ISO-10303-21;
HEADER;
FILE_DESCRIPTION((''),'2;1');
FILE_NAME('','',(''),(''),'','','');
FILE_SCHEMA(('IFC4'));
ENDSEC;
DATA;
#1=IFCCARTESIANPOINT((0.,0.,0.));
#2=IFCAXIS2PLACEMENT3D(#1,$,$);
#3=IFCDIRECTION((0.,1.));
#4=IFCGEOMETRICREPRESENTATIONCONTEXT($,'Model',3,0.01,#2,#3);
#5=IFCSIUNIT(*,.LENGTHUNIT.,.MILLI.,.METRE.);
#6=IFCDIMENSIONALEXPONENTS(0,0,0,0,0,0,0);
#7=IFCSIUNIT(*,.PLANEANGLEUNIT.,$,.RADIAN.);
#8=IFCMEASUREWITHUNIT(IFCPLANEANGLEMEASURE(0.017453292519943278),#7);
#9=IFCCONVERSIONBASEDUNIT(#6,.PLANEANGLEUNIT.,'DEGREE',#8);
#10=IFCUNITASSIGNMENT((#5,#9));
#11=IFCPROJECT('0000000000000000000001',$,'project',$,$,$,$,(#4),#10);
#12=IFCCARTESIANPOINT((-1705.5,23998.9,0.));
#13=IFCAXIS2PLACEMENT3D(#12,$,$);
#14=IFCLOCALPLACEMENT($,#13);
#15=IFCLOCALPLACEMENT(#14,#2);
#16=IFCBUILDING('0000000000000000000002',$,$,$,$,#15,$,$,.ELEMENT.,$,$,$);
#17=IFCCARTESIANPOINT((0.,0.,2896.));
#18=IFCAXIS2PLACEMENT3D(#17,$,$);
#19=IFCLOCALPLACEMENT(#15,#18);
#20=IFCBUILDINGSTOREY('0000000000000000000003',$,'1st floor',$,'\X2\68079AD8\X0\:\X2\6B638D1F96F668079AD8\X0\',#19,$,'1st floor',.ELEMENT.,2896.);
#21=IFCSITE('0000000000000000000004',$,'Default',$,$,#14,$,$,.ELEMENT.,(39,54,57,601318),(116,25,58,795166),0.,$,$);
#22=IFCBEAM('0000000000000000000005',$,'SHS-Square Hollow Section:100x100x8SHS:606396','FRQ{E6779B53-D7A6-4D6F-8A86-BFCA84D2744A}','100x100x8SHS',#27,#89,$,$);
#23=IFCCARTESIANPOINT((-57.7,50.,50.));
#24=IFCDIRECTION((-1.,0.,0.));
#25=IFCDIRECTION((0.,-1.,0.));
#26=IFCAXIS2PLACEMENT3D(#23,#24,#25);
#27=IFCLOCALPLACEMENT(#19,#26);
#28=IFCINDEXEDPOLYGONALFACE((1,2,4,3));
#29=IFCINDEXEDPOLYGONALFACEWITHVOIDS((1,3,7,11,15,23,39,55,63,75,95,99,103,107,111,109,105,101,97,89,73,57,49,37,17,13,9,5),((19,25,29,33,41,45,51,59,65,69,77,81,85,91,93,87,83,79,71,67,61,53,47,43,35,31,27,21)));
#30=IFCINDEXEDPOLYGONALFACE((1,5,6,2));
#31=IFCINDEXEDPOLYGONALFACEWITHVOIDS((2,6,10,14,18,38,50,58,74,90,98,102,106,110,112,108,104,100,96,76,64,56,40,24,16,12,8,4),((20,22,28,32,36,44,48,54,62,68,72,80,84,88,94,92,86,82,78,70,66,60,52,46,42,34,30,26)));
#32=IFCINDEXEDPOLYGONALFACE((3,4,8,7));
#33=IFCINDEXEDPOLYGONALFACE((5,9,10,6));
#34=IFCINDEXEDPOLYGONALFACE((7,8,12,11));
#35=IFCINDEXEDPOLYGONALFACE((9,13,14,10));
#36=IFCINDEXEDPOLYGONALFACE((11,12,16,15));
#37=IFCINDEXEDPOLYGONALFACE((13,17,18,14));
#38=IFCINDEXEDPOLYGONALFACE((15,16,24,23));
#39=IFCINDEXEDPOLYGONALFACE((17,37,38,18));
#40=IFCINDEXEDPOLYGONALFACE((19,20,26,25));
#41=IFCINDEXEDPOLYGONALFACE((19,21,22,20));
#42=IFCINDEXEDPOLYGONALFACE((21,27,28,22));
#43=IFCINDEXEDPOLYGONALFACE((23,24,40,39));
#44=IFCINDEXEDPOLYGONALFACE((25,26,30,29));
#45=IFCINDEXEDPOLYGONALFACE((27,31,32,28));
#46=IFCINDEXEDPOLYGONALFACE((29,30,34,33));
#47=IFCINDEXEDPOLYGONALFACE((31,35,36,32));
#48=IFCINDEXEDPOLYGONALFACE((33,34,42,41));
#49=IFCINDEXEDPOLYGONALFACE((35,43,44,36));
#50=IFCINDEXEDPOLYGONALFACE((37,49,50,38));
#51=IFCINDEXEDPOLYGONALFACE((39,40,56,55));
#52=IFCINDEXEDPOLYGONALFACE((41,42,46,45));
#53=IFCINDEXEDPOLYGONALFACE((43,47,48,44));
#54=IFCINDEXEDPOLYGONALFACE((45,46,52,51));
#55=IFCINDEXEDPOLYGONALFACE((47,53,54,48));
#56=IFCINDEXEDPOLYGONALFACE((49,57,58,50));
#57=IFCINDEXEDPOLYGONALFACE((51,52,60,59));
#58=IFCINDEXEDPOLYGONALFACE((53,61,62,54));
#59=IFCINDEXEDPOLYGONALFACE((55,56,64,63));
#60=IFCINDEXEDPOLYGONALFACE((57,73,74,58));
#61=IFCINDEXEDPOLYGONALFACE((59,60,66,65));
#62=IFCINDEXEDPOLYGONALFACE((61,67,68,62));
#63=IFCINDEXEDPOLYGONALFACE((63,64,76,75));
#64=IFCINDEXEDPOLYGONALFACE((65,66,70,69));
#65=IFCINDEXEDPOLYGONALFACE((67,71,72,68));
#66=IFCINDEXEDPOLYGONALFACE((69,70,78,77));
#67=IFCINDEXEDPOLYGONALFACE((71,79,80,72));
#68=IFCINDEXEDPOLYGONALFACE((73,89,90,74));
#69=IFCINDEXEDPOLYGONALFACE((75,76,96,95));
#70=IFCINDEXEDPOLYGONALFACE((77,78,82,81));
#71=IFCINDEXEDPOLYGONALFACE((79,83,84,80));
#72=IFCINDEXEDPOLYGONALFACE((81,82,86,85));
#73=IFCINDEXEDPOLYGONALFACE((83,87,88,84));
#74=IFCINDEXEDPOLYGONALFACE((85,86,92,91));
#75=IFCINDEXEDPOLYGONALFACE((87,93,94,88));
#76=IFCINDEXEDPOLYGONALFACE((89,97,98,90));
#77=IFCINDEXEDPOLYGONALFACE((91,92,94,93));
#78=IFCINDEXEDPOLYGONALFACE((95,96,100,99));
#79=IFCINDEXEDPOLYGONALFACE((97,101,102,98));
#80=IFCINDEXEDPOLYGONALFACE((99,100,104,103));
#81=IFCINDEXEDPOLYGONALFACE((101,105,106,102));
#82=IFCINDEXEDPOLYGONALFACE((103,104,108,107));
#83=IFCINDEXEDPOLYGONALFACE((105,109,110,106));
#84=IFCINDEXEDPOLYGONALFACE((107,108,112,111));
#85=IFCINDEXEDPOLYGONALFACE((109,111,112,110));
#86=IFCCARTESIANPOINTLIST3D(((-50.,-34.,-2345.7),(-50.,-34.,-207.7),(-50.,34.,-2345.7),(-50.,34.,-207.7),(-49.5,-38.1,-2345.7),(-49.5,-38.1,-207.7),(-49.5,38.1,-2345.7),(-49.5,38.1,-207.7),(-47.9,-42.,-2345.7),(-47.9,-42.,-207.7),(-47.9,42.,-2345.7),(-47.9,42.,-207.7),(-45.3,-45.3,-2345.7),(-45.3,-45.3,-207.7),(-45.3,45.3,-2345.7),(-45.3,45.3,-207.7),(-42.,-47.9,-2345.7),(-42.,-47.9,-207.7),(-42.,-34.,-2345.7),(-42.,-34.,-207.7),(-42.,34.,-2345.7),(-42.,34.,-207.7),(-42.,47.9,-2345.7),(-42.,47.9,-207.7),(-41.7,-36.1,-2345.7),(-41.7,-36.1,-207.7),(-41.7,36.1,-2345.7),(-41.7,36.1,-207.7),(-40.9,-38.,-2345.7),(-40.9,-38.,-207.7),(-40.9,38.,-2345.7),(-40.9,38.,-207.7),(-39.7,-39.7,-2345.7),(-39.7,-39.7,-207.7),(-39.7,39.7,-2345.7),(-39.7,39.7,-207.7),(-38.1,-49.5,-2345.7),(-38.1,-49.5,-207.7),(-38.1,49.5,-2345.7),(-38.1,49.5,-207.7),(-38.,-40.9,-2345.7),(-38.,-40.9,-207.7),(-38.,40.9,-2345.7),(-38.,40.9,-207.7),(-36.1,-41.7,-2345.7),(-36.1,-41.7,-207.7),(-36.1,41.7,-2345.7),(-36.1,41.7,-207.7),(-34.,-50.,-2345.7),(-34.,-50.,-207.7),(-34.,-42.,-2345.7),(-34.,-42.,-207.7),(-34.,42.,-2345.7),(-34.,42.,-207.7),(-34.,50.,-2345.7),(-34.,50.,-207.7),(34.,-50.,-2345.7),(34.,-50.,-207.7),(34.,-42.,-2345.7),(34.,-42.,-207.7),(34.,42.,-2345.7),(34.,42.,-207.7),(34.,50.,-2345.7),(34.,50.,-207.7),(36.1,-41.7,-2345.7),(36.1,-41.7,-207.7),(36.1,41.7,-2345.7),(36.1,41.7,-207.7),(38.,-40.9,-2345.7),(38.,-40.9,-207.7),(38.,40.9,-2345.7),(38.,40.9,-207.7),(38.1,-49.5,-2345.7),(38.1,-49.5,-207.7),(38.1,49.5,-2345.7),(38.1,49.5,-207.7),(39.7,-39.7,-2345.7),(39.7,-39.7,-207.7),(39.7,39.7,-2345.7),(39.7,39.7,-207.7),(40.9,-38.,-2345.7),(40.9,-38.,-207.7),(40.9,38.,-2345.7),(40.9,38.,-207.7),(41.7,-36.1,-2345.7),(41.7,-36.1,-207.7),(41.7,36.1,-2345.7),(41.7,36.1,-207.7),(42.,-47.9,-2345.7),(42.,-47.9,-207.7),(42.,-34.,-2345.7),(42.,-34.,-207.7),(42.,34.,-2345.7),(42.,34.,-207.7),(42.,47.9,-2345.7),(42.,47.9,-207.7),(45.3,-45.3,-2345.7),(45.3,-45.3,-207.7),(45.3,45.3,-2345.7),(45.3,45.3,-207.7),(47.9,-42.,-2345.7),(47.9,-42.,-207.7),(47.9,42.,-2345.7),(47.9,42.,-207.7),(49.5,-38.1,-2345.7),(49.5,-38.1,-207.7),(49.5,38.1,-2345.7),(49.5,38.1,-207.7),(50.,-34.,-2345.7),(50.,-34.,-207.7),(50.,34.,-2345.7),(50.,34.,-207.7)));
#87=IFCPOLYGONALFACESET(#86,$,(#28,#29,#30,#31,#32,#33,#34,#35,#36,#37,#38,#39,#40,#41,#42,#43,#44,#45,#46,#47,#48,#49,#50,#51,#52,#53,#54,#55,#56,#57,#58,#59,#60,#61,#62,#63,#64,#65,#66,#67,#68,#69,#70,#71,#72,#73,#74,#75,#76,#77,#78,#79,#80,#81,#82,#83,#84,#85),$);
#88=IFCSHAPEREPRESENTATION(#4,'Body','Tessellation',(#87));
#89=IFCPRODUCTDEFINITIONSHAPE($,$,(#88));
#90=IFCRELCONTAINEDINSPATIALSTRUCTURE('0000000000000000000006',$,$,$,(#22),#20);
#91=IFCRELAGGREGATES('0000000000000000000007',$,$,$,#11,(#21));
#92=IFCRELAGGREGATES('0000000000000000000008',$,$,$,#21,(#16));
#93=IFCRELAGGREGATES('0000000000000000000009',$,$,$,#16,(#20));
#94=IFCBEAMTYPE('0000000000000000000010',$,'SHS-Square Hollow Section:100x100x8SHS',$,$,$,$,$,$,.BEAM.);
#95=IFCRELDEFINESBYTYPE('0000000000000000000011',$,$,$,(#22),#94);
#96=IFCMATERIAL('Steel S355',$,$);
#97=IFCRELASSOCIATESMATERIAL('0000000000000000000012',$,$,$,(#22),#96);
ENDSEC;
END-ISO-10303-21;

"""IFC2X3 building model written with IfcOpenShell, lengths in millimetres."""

from ifc_helpers import new_model, entity, si_unit, converted_unit, direction, frame, origin, origin_2d, place, context, project, spatial, hollow_rectangle, extrude, clip, halfspace, material, type_object, element, save


model = new_model("IFC2X3")

# Units and contexts
model_context = context("Model", 3, precision=0.01, world=origin(), true_north=direction((0.0, 1.0)))
ifc_project = project(units=[si_unit("LENGTHUNIT", "METRE", prefix="MILLI"), converted_unit("PLANEANGLEUNIT", "DEGREE", entity("IfcPlaneAngleMeasure", 0.017453292519943278), si_unit("PLANEANGLEUNIT", "RADIAN"), dimensions=[0, 0, 0, 0, 0, 0, 0])], contexts=[model_context])

# Site, building, storey
site_placement = place(None, frame((-1705.5, 23998.9, 0.0)))
site = spatial("IfcSite", under=ifc_project, at=site_placement, Name="Default", CompositionType="ELEMENT", RefLatitude=(39, 54, 57, 601318), RefLongitude=(116, 25, 58, 795166), RefElevation=0.0)
building_placement = place(site_placement, origin())
building = spatial("IfcBuilding", under=site, at=building_placement, CompositionType="ELEMENT")
storey_placement = place(building_placement, frame((0.0, 0.0, 2896.0)))
storey = spatial("IfcBuildingStorey", under=building, at=storey_placement, Name="1st floor", ObjectType="标高:正负零标高", LongName="1st floor", CompositionType="ELEMENT", Elevation=2896.0)

# Shared definitions
ifc_material_1 = material(Name="Steel S355")

# Beam
beam_type_1 = type_object("IfcBeamType", Name="SHS-Square Hollow Section:100x100x8SHS", PredefinedType="BEAM")
beam_1_placement = place(storey_placement, frame((-57.7, 50.0, 50.0), z_axis=(-1.0, 0.0, 0.0), x_axis=(0.0, -1.0, 0.0)))
element("IfcBeam", 1, at=beam_1_placement, inside=storey, type_object=beam_type_1, material=ifc_material_1, Name="SHS-Square Hollow Section:100x100x8SHS:606396", Description="FRQ{E6779B53-D7A6-4D6F-8A86-BFCA84D2744A}", ObjectType="100x100x8SHS", context=model_context, shape_type="Clipping", body=[
    clip(clip(extrude(hollow_rectangle(XDim=100.0, YDim=100.0, WallThickness=8.0, InnerFilletRadius=8.0, OuterFilletRadius=16.0, at=origin_2d()), origin(), (0.0, 0.0, -1.0), 2551.4), halfspace(frame((50.0, -2946.0, -2345.7), z_axis=(0.0, 0.0, 1.0), x_axis=(1.0, 0.0, 0.0)), True)), halfspace(frame((50.0, -2946.0, -207.7), z_axis=(0.0, 0.0, -1.0), x_axis=(-1.0, 0.0, 0.0)), True)),
])

save(model, "model.ifc")
